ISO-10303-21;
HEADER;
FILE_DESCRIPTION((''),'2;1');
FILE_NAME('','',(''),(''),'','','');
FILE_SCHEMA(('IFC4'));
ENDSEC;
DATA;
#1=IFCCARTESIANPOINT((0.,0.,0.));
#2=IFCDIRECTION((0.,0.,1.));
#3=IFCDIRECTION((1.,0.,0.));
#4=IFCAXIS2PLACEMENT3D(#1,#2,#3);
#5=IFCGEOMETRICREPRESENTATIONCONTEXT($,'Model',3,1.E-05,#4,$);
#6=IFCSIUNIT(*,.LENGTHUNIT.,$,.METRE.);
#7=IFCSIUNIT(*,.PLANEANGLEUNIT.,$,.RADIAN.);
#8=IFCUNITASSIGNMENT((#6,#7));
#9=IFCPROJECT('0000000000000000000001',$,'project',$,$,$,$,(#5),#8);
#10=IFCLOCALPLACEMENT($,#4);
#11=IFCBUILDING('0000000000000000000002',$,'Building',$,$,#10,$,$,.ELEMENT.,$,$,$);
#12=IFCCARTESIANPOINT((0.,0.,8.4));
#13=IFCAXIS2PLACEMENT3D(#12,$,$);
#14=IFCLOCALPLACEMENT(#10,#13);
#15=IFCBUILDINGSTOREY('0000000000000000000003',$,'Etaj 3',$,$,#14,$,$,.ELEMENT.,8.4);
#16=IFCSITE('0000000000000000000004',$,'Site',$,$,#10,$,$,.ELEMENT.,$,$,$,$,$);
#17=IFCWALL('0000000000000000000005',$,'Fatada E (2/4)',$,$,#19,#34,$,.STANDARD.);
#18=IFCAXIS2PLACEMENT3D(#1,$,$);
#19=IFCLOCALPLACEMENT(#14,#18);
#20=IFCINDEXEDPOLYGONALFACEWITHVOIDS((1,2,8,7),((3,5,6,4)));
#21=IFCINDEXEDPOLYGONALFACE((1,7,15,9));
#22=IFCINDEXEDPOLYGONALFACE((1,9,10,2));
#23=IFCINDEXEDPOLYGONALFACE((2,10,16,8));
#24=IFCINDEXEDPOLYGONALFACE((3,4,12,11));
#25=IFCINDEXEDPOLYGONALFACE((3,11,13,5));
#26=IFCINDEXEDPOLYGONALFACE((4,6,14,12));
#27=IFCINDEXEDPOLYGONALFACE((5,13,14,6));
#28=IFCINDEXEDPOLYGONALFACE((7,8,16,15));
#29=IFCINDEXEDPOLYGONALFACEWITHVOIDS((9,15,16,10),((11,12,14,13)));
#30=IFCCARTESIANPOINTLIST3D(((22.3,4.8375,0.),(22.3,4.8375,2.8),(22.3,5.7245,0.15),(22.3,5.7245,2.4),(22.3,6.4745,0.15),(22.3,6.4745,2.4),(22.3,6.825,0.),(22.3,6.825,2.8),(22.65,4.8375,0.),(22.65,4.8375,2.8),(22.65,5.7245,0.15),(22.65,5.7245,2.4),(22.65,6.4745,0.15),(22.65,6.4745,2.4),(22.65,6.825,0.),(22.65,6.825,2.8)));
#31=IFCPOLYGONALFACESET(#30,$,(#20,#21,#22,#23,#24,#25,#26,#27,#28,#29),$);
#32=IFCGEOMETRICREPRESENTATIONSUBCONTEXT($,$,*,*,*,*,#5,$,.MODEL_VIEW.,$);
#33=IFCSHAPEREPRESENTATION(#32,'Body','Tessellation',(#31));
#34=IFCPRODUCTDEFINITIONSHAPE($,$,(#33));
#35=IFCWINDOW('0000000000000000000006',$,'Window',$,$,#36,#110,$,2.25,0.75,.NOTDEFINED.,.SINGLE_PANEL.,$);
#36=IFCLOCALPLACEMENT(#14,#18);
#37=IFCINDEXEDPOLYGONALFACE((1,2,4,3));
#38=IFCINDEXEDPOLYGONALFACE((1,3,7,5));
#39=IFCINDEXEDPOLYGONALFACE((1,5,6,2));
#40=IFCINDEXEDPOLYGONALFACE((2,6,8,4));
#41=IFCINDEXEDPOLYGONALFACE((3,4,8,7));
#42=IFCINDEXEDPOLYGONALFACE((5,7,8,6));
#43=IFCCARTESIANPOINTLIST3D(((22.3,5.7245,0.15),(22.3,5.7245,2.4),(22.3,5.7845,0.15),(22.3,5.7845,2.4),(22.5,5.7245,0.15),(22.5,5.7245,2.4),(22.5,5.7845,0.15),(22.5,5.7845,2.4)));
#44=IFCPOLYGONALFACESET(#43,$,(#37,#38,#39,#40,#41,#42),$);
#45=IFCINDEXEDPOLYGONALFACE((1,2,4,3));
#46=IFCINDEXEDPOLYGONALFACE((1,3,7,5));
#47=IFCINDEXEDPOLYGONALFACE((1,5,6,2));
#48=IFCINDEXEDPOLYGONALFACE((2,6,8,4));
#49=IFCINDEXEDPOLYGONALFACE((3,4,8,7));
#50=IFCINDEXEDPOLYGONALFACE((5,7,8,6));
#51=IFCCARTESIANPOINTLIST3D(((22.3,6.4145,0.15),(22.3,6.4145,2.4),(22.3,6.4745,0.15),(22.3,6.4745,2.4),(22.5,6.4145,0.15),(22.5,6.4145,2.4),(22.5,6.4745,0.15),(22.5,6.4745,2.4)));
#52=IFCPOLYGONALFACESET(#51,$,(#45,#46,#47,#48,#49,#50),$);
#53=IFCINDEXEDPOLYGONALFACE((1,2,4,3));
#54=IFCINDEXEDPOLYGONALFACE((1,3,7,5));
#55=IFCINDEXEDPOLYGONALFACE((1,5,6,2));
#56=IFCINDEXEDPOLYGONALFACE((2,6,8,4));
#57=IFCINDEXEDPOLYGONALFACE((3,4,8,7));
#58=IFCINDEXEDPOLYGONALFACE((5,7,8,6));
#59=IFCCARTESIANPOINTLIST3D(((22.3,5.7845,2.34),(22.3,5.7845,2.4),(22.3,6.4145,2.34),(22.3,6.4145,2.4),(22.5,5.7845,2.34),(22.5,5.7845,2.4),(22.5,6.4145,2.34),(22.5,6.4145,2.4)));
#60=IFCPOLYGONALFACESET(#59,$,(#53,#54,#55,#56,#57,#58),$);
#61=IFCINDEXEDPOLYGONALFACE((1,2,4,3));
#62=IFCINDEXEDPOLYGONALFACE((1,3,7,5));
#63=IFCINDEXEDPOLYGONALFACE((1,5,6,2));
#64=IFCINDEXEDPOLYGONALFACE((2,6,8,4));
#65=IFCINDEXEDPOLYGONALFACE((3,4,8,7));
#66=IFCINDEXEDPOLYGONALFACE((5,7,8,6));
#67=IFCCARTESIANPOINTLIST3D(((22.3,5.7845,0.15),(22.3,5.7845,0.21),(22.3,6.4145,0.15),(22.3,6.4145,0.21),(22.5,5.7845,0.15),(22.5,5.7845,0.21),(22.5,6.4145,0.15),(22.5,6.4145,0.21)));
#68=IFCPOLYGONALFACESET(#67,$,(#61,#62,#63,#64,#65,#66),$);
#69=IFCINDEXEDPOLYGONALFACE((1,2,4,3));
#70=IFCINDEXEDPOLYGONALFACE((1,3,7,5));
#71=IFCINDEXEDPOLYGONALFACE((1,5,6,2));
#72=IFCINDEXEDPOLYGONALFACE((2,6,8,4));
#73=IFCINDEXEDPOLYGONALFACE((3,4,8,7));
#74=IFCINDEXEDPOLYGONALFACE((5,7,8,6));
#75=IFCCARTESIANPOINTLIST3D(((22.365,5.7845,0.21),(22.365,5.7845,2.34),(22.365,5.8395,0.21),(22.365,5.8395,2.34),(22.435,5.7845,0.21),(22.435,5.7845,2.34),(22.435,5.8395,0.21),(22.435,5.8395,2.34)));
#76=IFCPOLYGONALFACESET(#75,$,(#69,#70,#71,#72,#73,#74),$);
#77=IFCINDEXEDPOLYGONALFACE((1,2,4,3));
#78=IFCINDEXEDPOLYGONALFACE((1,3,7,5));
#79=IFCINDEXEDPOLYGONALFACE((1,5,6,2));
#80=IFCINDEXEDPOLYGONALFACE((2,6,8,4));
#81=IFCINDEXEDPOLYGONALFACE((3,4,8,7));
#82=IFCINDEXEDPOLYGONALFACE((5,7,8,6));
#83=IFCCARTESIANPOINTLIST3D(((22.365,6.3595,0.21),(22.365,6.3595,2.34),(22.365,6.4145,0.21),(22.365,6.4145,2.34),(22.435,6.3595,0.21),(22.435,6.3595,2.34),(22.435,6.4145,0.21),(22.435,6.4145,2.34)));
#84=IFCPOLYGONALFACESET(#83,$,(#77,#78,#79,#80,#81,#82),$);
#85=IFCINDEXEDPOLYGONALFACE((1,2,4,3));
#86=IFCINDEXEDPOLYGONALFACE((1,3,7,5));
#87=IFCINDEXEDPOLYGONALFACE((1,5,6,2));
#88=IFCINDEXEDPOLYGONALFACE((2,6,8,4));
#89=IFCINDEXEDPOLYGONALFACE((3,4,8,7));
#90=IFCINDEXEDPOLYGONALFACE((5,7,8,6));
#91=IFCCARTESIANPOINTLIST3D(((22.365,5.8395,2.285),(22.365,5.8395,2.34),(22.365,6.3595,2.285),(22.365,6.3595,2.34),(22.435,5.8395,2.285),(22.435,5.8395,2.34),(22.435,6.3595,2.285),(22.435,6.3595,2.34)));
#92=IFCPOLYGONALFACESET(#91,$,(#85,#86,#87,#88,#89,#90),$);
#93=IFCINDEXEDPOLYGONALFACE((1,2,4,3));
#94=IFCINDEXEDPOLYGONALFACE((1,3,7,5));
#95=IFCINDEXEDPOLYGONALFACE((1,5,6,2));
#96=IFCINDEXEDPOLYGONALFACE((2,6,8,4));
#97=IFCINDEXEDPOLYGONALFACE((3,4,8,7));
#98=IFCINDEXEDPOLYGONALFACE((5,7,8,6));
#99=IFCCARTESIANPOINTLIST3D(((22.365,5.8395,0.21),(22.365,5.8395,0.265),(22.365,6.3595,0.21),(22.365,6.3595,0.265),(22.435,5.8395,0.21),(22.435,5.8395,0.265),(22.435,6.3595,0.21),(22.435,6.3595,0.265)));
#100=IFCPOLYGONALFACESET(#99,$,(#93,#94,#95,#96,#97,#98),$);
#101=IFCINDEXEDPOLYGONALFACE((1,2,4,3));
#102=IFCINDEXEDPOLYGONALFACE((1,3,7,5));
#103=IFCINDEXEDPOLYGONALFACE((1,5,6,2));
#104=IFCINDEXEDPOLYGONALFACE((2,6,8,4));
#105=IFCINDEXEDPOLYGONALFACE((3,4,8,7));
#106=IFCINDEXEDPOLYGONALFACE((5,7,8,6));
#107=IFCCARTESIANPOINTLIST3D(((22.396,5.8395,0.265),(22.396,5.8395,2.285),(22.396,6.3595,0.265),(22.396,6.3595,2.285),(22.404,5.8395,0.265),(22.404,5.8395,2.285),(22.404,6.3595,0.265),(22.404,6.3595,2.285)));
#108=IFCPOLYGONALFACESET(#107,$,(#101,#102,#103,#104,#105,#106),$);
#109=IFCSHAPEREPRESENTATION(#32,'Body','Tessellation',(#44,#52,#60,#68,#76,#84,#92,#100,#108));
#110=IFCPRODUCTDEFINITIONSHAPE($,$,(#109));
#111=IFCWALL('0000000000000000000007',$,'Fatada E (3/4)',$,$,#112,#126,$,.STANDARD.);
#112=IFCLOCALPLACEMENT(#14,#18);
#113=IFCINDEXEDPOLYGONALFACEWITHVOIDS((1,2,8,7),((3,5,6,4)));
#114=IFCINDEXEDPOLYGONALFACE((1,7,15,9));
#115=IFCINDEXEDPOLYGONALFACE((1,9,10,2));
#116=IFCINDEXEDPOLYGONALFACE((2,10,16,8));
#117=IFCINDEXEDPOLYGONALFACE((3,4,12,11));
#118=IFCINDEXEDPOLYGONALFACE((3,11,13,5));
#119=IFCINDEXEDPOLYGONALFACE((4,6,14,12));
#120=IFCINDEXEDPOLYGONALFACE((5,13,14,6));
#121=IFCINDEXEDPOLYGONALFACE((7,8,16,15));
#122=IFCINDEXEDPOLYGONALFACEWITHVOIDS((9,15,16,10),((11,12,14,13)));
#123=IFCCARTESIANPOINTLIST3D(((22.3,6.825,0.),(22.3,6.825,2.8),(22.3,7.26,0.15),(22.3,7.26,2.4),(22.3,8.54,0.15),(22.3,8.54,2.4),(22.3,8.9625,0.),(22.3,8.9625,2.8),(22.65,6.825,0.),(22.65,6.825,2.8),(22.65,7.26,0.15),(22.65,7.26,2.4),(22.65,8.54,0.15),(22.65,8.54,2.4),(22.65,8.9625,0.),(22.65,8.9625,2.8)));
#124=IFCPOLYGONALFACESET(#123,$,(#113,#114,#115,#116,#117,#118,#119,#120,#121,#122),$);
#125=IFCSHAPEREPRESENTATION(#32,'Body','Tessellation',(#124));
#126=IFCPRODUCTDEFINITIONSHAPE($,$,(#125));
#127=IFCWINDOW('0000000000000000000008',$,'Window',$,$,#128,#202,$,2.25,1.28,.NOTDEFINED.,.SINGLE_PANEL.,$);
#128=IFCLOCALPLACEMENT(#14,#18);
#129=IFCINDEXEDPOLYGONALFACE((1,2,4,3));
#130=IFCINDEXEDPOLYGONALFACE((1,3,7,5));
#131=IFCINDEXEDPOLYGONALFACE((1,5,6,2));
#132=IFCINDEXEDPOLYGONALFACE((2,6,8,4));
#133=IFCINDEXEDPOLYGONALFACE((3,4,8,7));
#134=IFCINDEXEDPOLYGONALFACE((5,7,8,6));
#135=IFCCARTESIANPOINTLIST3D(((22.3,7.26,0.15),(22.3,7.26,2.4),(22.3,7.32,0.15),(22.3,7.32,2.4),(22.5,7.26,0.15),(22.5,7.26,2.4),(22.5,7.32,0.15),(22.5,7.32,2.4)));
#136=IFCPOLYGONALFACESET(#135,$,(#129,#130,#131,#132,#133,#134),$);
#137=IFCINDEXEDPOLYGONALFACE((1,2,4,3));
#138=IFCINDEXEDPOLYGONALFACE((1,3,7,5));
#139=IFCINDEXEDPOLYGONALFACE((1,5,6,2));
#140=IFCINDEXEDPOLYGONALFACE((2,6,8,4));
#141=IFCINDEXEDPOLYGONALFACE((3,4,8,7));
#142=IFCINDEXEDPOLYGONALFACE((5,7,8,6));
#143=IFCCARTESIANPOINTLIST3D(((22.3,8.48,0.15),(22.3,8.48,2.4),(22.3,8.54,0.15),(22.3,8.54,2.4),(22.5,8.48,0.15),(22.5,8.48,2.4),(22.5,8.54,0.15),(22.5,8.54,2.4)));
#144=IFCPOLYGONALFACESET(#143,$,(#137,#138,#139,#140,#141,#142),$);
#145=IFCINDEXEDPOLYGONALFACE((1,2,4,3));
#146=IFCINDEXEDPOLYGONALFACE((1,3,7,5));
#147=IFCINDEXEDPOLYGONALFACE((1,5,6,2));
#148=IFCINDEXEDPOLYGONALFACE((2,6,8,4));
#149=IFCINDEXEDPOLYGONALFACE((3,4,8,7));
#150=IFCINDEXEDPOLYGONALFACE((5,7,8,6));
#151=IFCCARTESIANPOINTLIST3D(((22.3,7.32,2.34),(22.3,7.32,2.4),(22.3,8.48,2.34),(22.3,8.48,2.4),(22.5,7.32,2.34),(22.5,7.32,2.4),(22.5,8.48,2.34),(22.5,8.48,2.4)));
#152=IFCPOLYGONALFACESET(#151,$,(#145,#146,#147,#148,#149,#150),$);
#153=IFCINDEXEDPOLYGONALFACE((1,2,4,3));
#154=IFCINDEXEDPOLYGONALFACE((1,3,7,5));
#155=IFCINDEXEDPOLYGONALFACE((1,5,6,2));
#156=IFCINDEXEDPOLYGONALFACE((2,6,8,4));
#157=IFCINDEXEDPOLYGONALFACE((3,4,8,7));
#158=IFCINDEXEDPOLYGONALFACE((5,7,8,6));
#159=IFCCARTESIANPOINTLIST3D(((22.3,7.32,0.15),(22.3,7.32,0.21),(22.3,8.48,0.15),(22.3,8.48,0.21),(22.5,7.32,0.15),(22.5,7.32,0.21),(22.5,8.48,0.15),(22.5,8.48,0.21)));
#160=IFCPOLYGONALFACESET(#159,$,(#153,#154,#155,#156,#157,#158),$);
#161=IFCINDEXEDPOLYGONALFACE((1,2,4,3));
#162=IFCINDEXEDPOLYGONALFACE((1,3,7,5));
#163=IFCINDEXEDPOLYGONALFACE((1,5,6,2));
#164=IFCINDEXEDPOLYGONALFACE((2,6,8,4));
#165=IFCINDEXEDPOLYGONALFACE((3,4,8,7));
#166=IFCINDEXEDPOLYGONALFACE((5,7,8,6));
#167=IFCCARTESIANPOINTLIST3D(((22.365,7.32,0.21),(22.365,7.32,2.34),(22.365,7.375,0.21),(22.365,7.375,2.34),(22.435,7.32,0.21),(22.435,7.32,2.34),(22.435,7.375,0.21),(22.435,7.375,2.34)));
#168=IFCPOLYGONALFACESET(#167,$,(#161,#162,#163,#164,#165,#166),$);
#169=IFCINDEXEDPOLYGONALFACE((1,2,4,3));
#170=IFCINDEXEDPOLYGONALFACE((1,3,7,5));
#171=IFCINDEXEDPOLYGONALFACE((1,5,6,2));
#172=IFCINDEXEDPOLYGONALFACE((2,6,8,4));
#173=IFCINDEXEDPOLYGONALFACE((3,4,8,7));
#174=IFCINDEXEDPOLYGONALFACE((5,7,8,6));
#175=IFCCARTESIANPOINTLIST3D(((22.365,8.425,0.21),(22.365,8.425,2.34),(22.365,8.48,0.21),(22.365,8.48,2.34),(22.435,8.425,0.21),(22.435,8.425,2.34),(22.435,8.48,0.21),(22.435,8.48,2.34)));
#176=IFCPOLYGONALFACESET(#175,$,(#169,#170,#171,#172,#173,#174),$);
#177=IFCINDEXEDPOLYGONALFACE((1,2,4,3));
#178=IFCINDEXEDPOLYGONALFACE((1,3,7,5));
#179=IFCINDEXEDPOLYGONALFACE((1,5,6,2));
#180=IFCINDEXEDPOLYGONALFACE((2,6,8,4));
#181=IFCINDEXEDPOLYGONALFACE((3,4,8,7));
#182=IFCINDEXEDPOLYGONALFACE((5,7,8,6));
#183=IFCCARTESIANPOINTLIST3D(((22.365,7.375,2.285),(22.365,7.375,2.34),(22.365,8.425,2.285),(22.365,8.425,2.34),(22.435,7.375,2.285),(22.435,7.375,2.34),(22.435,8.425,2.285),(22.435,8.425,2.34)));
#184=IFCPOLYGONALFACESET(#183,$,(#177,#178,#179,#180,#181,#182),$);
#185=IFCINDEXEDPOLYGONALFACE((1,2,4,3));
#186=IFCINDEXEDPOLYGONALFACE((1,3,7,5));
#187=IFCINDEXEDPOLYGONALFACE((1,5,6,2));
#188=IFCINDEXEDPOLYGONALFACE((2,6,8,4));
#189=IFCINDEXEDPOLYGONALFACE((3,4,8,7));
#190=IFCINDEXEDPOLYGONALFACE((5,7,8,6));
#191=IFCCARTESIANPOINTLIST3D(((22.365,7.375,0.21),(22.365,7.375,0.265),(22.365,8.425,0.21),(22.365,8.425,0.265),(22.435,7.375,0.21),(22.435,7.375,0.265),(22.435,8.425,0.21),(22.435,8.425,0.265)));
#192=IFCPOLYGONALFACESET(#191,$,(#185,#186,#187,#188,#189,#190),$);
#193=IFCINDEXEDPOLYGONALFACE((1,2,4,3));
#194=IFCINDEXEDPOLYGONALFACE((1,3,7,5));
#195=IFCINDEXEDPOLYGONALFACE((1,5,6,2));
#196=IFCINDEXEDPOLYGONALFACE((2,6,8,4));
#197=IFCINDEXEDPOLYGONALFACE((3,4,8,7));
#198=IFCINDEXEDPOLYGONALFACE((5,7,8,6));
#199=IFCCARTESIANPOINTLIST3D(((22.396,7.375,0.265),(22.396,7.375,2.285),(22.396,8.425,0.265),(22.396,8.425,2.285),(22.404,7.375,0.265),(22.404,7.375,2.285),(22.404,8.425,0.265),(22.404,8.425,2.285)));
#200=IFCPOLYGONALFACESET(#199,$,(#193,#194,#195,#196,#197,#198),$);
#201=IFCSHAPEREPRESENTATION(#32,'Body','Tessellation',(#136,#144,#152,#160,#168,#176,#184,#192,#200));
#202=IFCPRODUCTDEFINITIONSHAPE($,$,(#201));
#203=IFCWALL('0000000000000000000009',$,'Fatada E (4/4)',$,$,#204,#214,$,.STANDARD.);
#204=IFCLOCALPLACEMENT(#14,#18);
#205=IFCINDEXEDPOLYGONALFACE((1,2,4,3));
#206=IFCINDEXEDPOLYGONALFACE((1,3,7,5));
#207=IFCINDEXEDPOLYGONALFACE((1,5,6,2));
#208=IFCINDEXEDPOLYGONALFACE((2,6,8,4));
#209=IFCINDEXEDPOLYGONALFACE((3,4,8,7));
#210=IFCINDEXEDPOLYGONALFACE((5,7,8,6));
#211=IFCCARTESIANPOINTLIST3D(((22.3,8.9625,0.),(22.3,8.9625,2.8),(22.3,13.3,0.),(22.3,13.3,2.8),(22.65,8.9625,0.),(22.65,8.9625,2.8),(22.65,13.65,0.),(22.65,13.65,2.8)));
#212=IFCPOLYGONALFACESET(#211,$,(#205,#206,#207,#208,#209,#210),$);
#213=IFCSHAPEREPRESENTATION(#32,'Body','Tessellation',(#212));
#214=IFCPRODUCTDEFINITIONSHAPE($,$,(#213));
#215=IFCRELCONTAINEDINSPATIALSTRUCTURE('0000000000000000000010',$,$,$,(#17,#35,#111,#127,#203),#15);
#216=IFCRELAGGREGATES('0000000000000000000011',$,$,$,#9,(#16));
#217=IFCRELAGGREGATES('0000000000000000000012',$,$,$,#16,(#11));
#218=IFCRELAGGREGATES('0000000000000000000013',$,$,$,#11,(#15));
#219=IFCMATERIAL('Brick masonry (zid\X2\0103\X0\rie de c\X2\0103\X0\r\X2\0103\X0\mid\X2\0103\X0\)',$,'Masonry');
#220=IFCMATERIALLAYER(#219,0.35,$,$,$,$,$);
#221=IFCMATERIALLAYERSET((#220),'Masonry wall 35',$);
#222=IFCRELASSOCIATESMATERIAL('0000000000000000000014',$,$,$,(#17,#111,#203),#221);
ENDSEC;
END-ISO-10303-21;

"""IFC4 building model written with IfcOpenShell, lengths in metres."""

from ifc_helpers import new_model, si_unit, frame, frame_2d, origin, origin_with_axes, origin_2d, place, context, subcontext, project, spatial, rectangle, extrude, clip, halfspace, material, layer, layer_set, layer_usage, element, fill, save


model = new_model("IFC4")

# Units and contexts
model_context = context("Model", 3, precision=1e-05, world=origin_with_axes())
sub_context = subcontext(model_context, None, None, "MODEL_VIEW")
ifc_project = project(units=[si_unit("LENGTHUNIT", "METRE"), si_unit("PLANEANGLEUNIT", "RADIAN")], contexts=[model_context])

# Site, building, storey
placement = place(None, origin_with_axes())
site = spatial("IfcSite", under=ifc_project, at=placement, Name="Site", CompositionType="ELEMENT")
building = spatial("IfcBuilding", under=site, at=placement, Name="Building", CompositionType="ELEMENT")
storey_placement = place(placement, frame((0.0, 0.0, 8.4)))
storey = spatial("IfcBuildingStorey", under=building, at=storey_placement, Name="Etaj 3", CompositionType="ELEMENT", Elevation=8.4)

# Walls, openings, windows
ifc_material_1 = material(Name="Brick masonry (zidărie de cărămidă)", Category="Masonry")
ifc_layer_1 = layer(ifc_material_1, 0.35)
ifc_layer_set_1 = layer_set([ifc_layer_1], Name="Masonry wall 35")
ifc_layer_usage_1 = layer_usage(ifc_layer_set_1, "AXIS2", "POSITIVE", -0.175)
wall_1_placement = place(storey_placement, frame((22.475, 4.8375, 0.0), x_axis=(0.0, 1.0, 0.0)))
wall_1 = element("IfcWall", 1, at=wall_1_placement, inside=storey, material=ifc_layer_usage_1, Name="Fatada E (2/4)", PredefinedType="STANDARD", context=sub_context, shape_type="SweptSolid", body=[
    extrude(rectangle(XDim=1.9875, YDim=0.35, at=frame_2d((0.9937, 0.0))), origin(), (0.0, 0.0, 1.0), 2.8),
])
opening_1_placement = place(wall_1_placement, frame((1.262, 0.225, 0.15), z_axis=(0.0, -1.0, 0.0), x_axis=(1.0, 0.0, 0.0)))
opening_1 = element("IfcOpeningElement", 2, at=opening_1_placement, cuts=wall_1, PredefinedType="OPENING", context=sub_context, shape_type="SweptSolid", body=[
    extrude(rectangle(XDim=0.75, YDim=2.25, at=frame_2d((0.0, 1.125))), origin(), (0.0, 0.0, 1.0), 0.45),
])
window_1_placement = place(wall_1_placement, frame((1.262, 0.175, 0.15), z_axis=(0.0, -1.0, 0.0), x_axis=(1.0, 0.0, 0.0)))
window_1 = element("IfcWindow", 3, at=window_1_placement, inside=storey, Name="Window", OverallHeight=2.25, OverallWidth=0.75, PartitioningType="SINGLE_PANEL", PredefinedType="NOTDEFINED", context=sub_context, shape_type="SweptSolid", body=[
    extrude(rectangle(XDim=0.06, YDim=2.25, at=origin_2d()), frame((-0.345, 1.125, 0.0)), (0.0, 0.0, 1.0), 0.2),
    extrude(rectangle(XDim=0.06, YDim=2.25, at=origin_2d()), frame((0.345, 1.125, 0.0)), (0.0, 0.0, 1.0), 0.2),
    extrude(rectangle(XDim=0.63, YDim=0.06, at=origin_2d()), frame((0.0, 2.22, 0.0)), (0.0, 0.0, 1.0), 0.2),
    extrude(rectangle(XDim=0.63, YDim=0.06, at=origin_2d()), frame((0.0, 0.03, 0.0)), (0.0, 0.0, 1.0), 0.2),
    extrude(rectangle(XDim=0.055, YDim=2.13, at=origin_2d()), frame((-0.2875, 1.125, 0.065)), (0.0, 0.0, 1.0), 0.07),
    extrude(rectangle(XDim=0.055, YDim=2.13, at=origin_2d()), frame((0.2875, 1.125, 0.065)), (0.0, 0.0, 1.0), 0.07),
    extrude(rectangle(XDim=0.52, YDim=0.055, at=origin_2d()), frame((0.0, 2.1625, 0.065)), (0.0, 0.0, 1.0), 0.07),
    extrude(rectangle(XDim=0.52, YDim=0.055, at=origin_2d()), frame((0.0, 0.0875, 0.065)), (0.0, 0.0, 1.0), 0.07),
    extrude(rectangle(XDim=0.52, YDim=2.02, at=origin_2d()), frame((0.0, 1.125, 0.096)), (0.0, 0.0, 1.0), 0.008),
])
fill(opening_1, window_1)
wall_2_placement = place(storey_placement, frame((22.475, 6.825, 0.0), x_axis=(0.0, 1.0, 0.0)))
wall_2 = element("IfcWall", 4, at=wall_2_placement, inside=storey, material=ifc_layer_usage_1, Name="Fatada E (3/4)", PredefinedType="STANDARD", context=sub_context, shape_type="SweptSolid", body=[
    extrude(rectangle(XDim=2.1375, YDim=0.35, at=frame_2d((1.0688, 0.0))), origin(), (0.0, 0.0, 1.0), 2.8),
])
opening_2_placement = place(wall_2_placement, frame((1.075, 0.225, 0.15), z_axis=(0.0, -1.0, 0.0), x_axis=(1.0, 0.0, 0.0)))
opening_2 = element("IfcOpeningElement", 5, at=opening_2_placement, cuts=wall_2, PredefinedType="OPENING", context=sub_context, shape_type="SweptSolid", body=[
    extrude(rectangle(XDim=1.28, YDim=2.25, at=frame_2d((0.0, 1.125))), origin(), (0.0, 0.0, 1.0), 0.45),
])
window_2_placement = place(wall_2_placement, frame((1.075, 0.175, 0.15), z_axis=(0.0, -1.0, 0.0), x_axis=(1.0, 0.0, 0.0)))
window_2 = element("IfcWindow", 6, at=window_2_placement, inside=storey, Name="Window", OverallHeight=2.25, OverallWidth=1.28, PartitioningType="SINGLE_PANEL", PredefinedType="NOTDEFINED", context=sub_context, shape_type="SweptSolid", body=[
    extrude(rectangle(XDim=0.06, YDim=2.25, at=origin_2d()), frame((-0.61, 1.125, 0.0)), (0.0, 0.0, 1.0), 0.2),
    extrude(rectangle(XDim=0.06, YDim=2.25, at=origin_2d()), frame((0.61, 1.125, 0.0)), (0.0, 0.0, 1.0), 0.2),
    extrude(rectangle(XDim=1.16, YDim=0.06, at=origin_2d()), frame((0.0, 2.22, 0.0)), (0.0, 0.0, 1.0), 0.2),
    extrude(rectangle(XDim=1.16, YDim=0.06, at=origin_2d()), frame((0.0, 0.03, 0.0)), (0.0, 0.0, 1.0), 0.2),
    extrude(rectangle(XDim=0.055, YDim=2.13, at=origin_2d()), frame((-0.5525, 1.125, 0.065)), (0.0, 0.0, 1.0), 0.07),
    extrude(rectangle(XDim=0.055, YDim=2.13, at=origin_2d()), frame((0.5525, 1.125, 0.065)), (0.0, 0.0, 1.0), 0.07),
    extrude(rectangle(XDim=1.05, YDim=0.055, at=origin_2d()), frame((0.0, 2.1625, 0.065)), (0.0, 0.0, 1.0), 0.07),
    extrude(rectangle(XDim=1.05, YDim=0.055, at=origin_2d()), frame((0.0, 0.0875, 0.065)), (0.0, 0.0, 1.0), 0.07),
    extrude(rectangle(XDim=1.05, YDim=2.02, at=origin_2d()), frame((0.0, 1.125, 0.096)), (0.0, 0.0, 1.0), 0.008),
])
fill(opening_2, window_2)

# Wall
wall_3_placement = place(storey_placement, frame((22.475, 8.9625, 0.0), x_axis=(0.0, 1.0, 0.0)))
element("IfcWall", 7, at=wall_3_placement, inside=storey, material=ifc_layer_usage_1, Name="Fatada E (4/4)", PredefinedType="STANDARD", context=sub_context, shape_type="CSG", body=[
    clip(extrude(rectangle(XDim=4.6875, YDim=0.35, at=frame_2d((2.3438, 0.0))), origin(), (0.0, 0.0, 1.0), 2.8), halfspace(frame((4.5125, 0.0, 0.0), z_axis=(0.707107, 0.707107, 0.0)), False)),
])

save(model, "model.ifc")
